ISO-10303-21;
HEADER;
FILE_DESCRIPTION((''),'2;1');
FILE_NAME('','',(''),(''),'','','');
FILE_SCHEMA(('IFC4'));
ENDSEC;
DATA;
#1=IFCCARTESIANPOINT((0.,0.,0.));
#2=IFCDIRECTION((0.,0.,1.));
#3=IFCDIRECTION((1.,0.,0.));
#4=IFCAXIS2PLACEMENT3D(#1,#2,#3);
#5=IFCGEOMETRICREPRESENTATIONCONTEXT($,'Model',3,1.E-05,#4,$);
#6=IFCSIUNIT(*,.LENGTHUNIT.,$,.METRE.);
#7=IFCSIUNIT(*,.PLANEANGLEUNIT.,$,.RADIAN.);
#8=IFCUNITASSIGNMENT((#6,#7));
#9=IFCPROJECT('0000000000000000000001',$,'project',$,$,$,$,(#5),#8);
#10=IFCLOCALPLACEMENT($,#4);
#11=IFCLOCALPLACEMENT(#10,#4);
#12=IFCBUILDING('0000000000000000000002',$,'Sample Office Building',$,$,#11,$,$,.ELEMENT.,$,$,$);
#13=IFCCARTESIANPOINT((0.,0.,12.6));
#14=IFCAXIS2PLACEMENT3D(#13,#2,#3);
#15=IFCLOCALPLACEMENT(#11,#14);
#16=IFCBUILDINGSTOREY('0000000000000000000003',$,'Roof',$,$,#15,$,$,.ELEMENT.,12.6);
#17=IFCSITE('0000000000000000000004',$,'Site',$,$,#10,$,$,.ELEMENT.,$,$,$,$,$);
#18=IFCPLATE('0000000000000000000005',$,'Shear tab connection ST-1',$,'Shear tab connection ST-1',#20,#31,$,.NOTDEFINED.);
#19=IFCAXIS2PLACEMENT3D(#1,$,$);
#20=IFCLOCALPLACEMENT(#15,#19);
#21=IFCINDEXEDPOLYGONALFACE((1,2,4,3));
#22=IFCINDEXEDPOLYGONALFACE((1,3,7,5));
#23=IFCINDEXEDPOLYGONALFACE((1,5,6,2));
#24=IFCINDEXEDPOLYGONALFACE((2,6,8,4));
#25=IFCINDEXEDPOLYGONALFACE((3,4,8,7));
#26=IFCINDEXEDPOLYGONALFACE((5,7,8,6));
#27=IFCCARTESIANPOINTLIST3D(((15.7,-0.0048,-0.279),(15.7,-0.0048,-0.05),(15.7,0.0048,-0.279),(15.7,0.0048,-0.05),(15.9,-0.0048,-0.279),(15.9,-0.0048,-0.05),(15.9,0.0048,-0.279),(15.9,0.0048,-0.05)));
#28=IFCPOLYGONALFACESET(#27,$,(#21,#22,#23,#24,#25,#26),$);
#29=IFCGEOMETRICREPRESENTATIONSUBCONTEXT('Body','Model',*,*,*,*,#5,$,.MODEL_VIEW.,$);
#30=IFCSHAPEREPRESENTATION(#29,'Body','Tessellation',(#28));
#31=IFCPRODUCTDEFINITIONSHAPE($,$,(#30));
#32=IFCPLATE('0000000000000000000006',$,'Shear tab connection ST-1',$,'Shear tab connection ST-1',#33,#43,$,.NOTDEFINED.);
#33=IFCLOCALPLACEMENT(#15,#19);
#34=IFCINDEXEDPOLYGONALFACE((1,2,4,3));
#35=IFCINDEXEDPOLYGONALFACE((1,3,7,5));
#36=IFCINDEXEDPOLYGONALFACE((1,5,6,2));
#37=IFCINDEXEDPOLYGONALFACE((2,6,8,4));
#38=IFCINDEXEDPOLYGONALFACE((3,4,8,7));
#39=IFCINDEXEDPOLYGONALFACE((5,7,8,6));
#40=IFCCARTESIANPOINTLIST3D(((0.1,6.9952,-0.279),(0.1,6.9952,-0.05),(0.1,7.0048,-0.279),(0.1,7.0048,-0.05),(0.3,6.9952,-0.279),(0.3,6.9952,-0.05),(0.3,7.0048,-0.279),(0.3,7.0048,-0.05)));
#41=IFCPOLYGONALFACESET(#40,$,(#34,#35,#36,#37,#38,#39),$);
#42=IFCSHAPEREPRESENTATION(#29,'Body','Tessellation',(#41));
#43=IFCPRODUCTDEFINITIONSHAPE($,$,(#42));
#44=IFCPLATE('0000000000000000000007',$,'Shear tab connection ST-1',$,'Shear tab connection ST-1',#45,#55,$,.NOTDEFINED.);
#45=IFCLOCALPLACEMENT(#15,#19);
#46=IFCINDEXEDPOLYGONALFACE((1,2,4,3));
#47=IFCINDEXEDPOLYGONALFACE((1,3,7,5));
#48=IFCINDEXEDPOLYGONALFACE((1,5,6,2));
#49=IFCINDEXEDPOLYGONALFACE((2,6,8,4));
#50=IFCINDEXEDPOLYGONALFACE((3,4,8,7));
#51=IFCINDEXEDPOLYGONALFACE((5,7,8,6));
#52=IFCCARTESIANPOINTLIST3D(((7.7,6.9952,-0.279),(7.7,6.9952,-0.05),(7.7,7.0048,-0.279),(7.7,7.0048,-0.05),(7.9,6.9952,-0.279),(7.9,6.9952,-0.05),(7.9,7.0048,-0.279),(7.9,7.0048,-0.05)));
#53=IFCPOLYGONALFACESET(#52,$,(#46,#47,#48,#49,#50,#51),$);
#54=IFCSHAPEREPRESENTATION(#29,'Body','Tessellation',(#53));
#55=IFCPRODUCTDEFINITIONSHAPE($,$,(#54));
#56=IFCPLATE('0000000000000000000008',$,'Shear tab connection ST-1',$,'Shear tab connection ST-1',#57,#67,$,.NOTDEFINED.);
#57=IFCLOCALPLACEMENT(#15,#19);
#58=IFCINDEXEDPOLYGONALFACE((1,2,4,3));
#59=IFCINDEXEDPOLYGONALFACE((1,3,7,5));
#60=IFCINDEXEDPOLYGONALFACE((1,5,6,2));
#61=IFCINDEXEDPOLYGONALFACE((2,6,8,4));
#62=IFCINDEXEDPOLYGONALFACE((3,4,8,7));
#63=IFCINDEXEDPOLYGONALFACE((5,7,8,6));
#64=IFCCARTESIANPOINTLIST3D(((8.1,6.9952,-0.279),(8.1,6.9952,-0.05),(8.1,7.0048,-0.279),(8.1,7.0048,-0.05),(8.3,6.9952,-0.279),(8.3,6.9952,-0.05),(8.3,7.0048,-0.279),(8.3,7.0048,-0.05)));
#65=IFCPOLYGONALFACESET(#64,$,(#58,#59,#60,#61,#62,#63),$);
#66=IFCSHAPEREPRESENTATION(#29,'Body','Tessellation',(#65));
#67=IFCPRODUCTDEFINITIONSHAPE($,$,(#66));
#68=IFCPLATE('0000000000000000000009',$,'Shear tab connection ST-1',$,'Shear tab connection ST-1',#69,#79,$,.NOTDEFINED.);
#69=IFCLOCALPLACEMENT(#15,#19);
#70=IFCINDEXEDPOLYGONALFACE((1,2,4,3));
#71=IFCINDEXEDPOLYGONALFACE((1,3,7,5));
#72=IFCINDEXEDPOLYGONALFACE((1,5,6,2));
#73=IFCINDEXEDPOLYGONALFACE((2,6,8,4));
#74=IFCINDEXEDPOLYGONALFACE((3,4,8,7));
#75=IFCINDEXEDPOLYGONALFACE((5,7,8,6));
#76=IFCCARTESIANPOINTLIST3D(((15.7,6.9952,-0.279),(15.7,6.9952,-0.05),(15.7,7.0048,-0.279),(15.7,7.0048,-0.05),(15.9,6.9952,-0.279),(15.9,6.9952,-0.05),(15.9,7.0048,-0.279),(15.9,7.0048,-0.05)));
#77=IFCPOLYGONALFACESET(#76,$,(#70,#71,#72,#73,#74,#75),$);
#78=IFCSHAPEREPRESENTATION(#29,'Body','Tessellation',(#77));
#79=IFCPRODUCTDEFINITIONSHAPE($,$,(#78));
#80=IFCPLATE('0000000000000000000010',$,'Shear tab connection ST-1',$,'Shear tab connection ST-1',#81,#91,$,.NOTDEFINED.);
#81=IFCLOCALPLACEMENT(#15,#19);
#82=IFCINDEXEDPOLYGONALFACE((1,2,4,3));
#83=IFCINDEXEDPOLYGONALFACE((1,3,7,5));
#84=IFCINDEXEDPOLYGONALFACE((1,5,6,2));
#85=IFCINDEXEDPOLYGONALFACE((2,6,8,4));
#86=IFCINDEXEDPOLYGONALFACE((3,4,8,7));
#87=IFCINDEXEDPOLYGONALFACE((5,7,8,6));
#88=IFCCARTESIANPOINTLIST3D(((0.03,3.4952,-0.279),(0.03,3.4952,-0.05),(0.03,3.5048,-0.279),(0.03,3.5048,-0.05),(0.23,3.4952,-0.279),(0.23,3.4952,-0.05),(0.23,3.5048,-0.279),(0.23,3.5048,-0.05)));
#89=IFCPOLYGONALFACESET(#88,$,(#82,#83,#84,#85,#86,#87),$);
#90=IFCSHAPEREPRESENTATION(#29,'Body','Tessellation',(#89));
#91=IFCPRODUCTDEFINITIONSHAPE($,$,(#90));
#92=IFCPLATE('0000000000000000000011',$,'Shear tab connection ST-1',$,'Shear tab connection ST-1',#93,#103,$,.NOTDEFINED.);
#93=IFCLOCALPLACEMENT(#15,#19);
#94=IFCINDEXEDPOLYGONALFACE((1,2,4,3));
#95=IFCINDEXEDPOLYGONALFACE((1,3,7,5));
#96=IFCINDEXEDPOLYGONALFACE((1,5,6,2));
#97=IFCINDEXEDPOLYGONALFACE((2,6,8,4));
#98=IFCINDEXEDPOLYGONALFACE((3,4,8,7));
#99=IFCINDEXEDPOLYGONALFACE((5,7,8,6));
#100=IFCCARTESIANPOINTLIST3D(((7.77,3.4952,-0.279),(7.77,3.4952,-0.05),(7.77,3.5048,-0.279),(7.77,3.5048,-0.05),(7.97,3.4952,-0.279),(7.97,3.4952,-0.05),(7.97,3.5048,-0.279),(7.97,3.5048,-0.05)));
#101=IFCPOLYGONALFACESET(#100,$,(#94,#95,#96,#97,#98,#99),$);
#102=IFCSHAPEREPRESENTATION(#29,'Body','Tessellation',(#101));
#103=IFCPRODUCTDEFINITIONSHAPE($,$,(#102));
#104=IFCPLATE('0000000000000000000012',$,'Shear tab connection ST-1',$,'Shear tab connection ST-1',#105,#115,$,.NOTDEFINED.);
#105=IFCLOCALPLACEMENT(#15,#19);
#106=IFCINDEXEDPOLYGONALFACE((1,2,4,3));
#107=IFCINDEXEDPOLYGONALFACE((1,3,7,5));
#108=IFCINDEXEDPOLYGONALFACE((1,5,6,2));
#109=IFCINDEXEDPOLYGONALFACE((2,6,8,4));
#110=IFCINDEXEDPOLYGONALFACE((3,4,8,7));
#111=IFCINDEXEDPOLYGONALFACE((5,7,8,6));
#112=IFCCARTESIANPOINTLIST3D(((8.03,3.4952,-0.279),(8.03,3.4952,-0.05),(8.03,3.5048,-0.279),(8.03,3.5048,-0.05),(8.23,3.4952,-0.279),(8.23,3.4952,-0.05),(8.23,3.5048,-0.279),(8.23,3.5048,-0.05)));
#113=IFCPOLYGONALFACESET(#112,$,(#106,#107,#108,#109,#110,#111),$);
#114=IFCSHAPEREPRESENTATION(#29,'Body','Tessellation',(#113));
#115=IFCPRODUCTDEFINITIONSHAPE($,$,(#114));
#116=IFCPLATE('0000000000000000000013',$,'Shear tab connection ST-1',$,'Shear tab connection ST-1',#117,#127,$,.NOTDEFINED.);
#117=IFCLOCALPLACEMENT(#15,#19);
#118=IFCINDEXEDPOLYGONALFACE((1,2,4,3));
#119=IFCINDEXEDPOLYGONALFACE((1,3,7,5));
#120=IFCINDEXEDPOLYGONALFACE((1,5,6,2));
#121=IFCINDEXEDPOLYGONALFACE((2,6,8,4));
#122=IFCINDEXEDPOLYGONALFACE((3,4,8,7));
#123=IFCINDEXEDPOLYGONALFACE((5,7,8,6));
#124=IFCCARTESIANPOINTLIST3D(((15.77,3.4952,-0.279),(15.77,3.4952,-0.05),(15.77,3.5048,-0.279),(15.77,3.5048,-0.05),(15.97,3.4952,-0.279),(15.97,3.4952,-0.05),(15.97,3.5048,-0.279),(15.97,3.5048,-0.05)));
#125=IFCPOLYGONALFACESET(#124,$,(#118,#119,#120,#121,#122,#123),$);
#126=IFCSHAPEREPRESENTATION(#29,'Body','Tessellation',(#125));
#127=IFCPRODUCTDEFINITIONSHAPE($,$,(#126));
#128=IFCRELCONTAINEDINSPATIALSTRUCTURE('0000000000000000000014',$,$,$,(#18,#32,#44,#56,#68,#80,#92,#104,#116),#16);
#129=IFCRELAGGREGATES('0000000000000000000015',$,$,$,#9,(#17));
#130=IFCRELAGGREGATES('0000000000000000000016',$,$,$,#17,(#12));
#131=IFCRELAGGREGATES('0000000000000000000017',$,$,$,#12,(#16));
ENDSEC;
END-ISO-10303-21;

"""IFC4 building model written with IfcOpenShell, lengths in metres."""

from ifc_helpers import new_model, si_unit, frame, origin_with_axes, place, context, subcontext, project, spatial, rectangle, extrude, element, save


model = new_model("IFC4")

# Units and contexts
model_context = context("Model", 3, precision=1e-05, world=origin_with_axes())
body_context = subcontext(model_context, "Body", "Model", "MODEL_VIEW")
ifc_project = project(units=[si_unit("LENGTHUNIT", "METRE"), si_unit("PLANEANGLEUNIT", "RADIAN")], contexts=[model_context])

# Site, building, storey
site_placement = place(None, origin_with_axes())
site = spatial("IfcSite", under=ifc_project, at=site_placement, Name="Site", CompositionType="ELEMENT")
building_placement = place(site_placement, origin_with_axes())
building = spatial("IfcBuilding", under=site, at=building_placement, Name="Sample Office Building", CompositionType="ELEMENT")
storey_placement = place(building_placement, frame((0.0, 0.0, 12.6), z_axis=(0.0, 0.0, 1.0), x_axis=(1.0, 0.0, 0.0)))
storey = spatial("IfcBuildingStorey", under=building, at=storey_placement, Name="Roof", CompositionType="ELEMENT", Elevation=12.6)

# Plates
for number, where, z_axis, x_axis, name in (
    (1, (15.8, 0.0, 12.321), (0.0, 0.0, 1.0), (1.0, 0.0, 0.0), "Shear tab connection ST-1"),
):
    element("IfcPlate", number, at=place(None, frame(where, z_axis=z_axis, x_axis=x_axis)), inside=storey, Name=name, ObjectType="Shear tab connection ST-1", PredefinedType="NOTDEFINED", context=body_context, shape_type="SweptSolid", body=[
        extrude(rectangle(XDim=0.2, YDim=0.0095), None, (0.0, 0.0, 1.0), 0.229),
    ])
plate_1_placement = place(None, frame((0.2, 7.0, 12.321), z_axis=(0.0, 0.0, 1.0), x_axis=(1.0, 0.0, 0.0)))
element("IfcPlate", 2, at=plate_1_placement, inside=storey, Name="Shear tab connection ST-1", ObjectType="Shear tab connection ST-1", PredefinedType="NOTDEFINED", context=body_context, shape_type="SweptSolid", body=[
    extrude(rectangle(XDim=0.2, YDim=0.0095), None, (0.0, 0.0, 1.0), 0.229),
])
plate_2_placement = place(None, frame((7.8, 7.0, 12.321), z_axis=(0.0, 0.0, 1.0), x_axis=(1.0, 0.0, 0.0)))
element("IfcPlate", 3, at=plate_2_placement, inside=storey, Name="Shear tab connection ST-1", ObjectType="Shear tab connection ST-1", PredefinedType="NOTDEFINED", context=body_context, shape_type="SweptSolid", body=[
    extrude(rectangle(XDim=0.2, YDim=0.0095), None, (0.0, 0.0, 1.0), 0.229),
])
for number, where, z_axis, x_axis, name in (
    (4, (8.2, 7.0, 12.321), (0.0, 0.0, 1.0), (1.0, 0.0, 0.0), "Shear tab connection ST-1"),
    (5, (15.8, 7.0, 12.321), (0.0, 0.0, 1.0), (1.0, 0.0, 0.0), "Shear tab connection ST-1"),
):
    element("IfcPlate", number, at=place(None, frame(where, z_axis=z_axis, x_axis=x_axis)), inside=storey, Name=name, ObjectType="Shear tab connection ST-1", PredefinedType="NOTDEFINED", context=body_context, shape_type="SweptSolid", body=[
        extrude(rectangle(XDim=0.2, YDim=0.0095), None, (0.0, 0.0, 1.0), 0.229),
    ])
plate_3_placement = place(None, frame((0.13, 3.5, 12.321), z_axis=(0.0, 0.0, 1.0), x_axis=(1.0, 0.0, 0.0)))
element("IfcPlate", 6, at=plate_3_placement, inside=storey, Name="Shear tab connection ST-1", ObjectType="Shear tab connection ST-1", PredefinedType="NOTDEFINED", context=body_context, shape_type="SweptSolid", body=[
    extrude(rectangle(XDim=0.2, YDim=0.0095), None, (0.0, 0.0, 1.0), 0.229),
])
plate_4_placement = place(None, frame((7.87, 3.5, 12.321), z_axis=(0.0, 0.0, 1.0), x_axis=(1.0, 0.0, 0.0)))
element("IfcPlate", 7, at=plate_4_placement, inside=storey, Name="Shear tab connection ST-1", ObjectType="Shear tab connection ST-1", PredefinedType="NOTDEFINED", context=body_context, shape_type="SweptSolid", body=[
    extrude(rectangle(XDim=0.2, YDim=0.0095), None, (0.0, 0.0, 1.0), 0.229),
])
for number, where, z_axis, x_axis, name in (
    (8, (8.13, 3.5, 12.321), (0.0, 0.0, 1.0), (1.0, 0.0, 0.0), "Shear tab connection ST-1"),
    (9, (15.87, 3.5, 12.321), (0.0, 0.0, 1.0), (1.0, 0.0, 0.0), "Shear tab connection ST-1"),
):
    element("IfcPlate", number, at=place(None, frame(where, z_axis=z_axis, x_axis=x_axis)), inside=storey, Name=name, ObjectType="Shear tab connection ST-1", PredefinedType="NOTDEFINED", context=body_context, shape_type="SweptSolid", body=[
        extrude(rectangle(XDim=0.2, YDim=0.0095), None, (0.0, 0.0, 1.0), 0.229),
    ])

save(model, "model.ifc")
